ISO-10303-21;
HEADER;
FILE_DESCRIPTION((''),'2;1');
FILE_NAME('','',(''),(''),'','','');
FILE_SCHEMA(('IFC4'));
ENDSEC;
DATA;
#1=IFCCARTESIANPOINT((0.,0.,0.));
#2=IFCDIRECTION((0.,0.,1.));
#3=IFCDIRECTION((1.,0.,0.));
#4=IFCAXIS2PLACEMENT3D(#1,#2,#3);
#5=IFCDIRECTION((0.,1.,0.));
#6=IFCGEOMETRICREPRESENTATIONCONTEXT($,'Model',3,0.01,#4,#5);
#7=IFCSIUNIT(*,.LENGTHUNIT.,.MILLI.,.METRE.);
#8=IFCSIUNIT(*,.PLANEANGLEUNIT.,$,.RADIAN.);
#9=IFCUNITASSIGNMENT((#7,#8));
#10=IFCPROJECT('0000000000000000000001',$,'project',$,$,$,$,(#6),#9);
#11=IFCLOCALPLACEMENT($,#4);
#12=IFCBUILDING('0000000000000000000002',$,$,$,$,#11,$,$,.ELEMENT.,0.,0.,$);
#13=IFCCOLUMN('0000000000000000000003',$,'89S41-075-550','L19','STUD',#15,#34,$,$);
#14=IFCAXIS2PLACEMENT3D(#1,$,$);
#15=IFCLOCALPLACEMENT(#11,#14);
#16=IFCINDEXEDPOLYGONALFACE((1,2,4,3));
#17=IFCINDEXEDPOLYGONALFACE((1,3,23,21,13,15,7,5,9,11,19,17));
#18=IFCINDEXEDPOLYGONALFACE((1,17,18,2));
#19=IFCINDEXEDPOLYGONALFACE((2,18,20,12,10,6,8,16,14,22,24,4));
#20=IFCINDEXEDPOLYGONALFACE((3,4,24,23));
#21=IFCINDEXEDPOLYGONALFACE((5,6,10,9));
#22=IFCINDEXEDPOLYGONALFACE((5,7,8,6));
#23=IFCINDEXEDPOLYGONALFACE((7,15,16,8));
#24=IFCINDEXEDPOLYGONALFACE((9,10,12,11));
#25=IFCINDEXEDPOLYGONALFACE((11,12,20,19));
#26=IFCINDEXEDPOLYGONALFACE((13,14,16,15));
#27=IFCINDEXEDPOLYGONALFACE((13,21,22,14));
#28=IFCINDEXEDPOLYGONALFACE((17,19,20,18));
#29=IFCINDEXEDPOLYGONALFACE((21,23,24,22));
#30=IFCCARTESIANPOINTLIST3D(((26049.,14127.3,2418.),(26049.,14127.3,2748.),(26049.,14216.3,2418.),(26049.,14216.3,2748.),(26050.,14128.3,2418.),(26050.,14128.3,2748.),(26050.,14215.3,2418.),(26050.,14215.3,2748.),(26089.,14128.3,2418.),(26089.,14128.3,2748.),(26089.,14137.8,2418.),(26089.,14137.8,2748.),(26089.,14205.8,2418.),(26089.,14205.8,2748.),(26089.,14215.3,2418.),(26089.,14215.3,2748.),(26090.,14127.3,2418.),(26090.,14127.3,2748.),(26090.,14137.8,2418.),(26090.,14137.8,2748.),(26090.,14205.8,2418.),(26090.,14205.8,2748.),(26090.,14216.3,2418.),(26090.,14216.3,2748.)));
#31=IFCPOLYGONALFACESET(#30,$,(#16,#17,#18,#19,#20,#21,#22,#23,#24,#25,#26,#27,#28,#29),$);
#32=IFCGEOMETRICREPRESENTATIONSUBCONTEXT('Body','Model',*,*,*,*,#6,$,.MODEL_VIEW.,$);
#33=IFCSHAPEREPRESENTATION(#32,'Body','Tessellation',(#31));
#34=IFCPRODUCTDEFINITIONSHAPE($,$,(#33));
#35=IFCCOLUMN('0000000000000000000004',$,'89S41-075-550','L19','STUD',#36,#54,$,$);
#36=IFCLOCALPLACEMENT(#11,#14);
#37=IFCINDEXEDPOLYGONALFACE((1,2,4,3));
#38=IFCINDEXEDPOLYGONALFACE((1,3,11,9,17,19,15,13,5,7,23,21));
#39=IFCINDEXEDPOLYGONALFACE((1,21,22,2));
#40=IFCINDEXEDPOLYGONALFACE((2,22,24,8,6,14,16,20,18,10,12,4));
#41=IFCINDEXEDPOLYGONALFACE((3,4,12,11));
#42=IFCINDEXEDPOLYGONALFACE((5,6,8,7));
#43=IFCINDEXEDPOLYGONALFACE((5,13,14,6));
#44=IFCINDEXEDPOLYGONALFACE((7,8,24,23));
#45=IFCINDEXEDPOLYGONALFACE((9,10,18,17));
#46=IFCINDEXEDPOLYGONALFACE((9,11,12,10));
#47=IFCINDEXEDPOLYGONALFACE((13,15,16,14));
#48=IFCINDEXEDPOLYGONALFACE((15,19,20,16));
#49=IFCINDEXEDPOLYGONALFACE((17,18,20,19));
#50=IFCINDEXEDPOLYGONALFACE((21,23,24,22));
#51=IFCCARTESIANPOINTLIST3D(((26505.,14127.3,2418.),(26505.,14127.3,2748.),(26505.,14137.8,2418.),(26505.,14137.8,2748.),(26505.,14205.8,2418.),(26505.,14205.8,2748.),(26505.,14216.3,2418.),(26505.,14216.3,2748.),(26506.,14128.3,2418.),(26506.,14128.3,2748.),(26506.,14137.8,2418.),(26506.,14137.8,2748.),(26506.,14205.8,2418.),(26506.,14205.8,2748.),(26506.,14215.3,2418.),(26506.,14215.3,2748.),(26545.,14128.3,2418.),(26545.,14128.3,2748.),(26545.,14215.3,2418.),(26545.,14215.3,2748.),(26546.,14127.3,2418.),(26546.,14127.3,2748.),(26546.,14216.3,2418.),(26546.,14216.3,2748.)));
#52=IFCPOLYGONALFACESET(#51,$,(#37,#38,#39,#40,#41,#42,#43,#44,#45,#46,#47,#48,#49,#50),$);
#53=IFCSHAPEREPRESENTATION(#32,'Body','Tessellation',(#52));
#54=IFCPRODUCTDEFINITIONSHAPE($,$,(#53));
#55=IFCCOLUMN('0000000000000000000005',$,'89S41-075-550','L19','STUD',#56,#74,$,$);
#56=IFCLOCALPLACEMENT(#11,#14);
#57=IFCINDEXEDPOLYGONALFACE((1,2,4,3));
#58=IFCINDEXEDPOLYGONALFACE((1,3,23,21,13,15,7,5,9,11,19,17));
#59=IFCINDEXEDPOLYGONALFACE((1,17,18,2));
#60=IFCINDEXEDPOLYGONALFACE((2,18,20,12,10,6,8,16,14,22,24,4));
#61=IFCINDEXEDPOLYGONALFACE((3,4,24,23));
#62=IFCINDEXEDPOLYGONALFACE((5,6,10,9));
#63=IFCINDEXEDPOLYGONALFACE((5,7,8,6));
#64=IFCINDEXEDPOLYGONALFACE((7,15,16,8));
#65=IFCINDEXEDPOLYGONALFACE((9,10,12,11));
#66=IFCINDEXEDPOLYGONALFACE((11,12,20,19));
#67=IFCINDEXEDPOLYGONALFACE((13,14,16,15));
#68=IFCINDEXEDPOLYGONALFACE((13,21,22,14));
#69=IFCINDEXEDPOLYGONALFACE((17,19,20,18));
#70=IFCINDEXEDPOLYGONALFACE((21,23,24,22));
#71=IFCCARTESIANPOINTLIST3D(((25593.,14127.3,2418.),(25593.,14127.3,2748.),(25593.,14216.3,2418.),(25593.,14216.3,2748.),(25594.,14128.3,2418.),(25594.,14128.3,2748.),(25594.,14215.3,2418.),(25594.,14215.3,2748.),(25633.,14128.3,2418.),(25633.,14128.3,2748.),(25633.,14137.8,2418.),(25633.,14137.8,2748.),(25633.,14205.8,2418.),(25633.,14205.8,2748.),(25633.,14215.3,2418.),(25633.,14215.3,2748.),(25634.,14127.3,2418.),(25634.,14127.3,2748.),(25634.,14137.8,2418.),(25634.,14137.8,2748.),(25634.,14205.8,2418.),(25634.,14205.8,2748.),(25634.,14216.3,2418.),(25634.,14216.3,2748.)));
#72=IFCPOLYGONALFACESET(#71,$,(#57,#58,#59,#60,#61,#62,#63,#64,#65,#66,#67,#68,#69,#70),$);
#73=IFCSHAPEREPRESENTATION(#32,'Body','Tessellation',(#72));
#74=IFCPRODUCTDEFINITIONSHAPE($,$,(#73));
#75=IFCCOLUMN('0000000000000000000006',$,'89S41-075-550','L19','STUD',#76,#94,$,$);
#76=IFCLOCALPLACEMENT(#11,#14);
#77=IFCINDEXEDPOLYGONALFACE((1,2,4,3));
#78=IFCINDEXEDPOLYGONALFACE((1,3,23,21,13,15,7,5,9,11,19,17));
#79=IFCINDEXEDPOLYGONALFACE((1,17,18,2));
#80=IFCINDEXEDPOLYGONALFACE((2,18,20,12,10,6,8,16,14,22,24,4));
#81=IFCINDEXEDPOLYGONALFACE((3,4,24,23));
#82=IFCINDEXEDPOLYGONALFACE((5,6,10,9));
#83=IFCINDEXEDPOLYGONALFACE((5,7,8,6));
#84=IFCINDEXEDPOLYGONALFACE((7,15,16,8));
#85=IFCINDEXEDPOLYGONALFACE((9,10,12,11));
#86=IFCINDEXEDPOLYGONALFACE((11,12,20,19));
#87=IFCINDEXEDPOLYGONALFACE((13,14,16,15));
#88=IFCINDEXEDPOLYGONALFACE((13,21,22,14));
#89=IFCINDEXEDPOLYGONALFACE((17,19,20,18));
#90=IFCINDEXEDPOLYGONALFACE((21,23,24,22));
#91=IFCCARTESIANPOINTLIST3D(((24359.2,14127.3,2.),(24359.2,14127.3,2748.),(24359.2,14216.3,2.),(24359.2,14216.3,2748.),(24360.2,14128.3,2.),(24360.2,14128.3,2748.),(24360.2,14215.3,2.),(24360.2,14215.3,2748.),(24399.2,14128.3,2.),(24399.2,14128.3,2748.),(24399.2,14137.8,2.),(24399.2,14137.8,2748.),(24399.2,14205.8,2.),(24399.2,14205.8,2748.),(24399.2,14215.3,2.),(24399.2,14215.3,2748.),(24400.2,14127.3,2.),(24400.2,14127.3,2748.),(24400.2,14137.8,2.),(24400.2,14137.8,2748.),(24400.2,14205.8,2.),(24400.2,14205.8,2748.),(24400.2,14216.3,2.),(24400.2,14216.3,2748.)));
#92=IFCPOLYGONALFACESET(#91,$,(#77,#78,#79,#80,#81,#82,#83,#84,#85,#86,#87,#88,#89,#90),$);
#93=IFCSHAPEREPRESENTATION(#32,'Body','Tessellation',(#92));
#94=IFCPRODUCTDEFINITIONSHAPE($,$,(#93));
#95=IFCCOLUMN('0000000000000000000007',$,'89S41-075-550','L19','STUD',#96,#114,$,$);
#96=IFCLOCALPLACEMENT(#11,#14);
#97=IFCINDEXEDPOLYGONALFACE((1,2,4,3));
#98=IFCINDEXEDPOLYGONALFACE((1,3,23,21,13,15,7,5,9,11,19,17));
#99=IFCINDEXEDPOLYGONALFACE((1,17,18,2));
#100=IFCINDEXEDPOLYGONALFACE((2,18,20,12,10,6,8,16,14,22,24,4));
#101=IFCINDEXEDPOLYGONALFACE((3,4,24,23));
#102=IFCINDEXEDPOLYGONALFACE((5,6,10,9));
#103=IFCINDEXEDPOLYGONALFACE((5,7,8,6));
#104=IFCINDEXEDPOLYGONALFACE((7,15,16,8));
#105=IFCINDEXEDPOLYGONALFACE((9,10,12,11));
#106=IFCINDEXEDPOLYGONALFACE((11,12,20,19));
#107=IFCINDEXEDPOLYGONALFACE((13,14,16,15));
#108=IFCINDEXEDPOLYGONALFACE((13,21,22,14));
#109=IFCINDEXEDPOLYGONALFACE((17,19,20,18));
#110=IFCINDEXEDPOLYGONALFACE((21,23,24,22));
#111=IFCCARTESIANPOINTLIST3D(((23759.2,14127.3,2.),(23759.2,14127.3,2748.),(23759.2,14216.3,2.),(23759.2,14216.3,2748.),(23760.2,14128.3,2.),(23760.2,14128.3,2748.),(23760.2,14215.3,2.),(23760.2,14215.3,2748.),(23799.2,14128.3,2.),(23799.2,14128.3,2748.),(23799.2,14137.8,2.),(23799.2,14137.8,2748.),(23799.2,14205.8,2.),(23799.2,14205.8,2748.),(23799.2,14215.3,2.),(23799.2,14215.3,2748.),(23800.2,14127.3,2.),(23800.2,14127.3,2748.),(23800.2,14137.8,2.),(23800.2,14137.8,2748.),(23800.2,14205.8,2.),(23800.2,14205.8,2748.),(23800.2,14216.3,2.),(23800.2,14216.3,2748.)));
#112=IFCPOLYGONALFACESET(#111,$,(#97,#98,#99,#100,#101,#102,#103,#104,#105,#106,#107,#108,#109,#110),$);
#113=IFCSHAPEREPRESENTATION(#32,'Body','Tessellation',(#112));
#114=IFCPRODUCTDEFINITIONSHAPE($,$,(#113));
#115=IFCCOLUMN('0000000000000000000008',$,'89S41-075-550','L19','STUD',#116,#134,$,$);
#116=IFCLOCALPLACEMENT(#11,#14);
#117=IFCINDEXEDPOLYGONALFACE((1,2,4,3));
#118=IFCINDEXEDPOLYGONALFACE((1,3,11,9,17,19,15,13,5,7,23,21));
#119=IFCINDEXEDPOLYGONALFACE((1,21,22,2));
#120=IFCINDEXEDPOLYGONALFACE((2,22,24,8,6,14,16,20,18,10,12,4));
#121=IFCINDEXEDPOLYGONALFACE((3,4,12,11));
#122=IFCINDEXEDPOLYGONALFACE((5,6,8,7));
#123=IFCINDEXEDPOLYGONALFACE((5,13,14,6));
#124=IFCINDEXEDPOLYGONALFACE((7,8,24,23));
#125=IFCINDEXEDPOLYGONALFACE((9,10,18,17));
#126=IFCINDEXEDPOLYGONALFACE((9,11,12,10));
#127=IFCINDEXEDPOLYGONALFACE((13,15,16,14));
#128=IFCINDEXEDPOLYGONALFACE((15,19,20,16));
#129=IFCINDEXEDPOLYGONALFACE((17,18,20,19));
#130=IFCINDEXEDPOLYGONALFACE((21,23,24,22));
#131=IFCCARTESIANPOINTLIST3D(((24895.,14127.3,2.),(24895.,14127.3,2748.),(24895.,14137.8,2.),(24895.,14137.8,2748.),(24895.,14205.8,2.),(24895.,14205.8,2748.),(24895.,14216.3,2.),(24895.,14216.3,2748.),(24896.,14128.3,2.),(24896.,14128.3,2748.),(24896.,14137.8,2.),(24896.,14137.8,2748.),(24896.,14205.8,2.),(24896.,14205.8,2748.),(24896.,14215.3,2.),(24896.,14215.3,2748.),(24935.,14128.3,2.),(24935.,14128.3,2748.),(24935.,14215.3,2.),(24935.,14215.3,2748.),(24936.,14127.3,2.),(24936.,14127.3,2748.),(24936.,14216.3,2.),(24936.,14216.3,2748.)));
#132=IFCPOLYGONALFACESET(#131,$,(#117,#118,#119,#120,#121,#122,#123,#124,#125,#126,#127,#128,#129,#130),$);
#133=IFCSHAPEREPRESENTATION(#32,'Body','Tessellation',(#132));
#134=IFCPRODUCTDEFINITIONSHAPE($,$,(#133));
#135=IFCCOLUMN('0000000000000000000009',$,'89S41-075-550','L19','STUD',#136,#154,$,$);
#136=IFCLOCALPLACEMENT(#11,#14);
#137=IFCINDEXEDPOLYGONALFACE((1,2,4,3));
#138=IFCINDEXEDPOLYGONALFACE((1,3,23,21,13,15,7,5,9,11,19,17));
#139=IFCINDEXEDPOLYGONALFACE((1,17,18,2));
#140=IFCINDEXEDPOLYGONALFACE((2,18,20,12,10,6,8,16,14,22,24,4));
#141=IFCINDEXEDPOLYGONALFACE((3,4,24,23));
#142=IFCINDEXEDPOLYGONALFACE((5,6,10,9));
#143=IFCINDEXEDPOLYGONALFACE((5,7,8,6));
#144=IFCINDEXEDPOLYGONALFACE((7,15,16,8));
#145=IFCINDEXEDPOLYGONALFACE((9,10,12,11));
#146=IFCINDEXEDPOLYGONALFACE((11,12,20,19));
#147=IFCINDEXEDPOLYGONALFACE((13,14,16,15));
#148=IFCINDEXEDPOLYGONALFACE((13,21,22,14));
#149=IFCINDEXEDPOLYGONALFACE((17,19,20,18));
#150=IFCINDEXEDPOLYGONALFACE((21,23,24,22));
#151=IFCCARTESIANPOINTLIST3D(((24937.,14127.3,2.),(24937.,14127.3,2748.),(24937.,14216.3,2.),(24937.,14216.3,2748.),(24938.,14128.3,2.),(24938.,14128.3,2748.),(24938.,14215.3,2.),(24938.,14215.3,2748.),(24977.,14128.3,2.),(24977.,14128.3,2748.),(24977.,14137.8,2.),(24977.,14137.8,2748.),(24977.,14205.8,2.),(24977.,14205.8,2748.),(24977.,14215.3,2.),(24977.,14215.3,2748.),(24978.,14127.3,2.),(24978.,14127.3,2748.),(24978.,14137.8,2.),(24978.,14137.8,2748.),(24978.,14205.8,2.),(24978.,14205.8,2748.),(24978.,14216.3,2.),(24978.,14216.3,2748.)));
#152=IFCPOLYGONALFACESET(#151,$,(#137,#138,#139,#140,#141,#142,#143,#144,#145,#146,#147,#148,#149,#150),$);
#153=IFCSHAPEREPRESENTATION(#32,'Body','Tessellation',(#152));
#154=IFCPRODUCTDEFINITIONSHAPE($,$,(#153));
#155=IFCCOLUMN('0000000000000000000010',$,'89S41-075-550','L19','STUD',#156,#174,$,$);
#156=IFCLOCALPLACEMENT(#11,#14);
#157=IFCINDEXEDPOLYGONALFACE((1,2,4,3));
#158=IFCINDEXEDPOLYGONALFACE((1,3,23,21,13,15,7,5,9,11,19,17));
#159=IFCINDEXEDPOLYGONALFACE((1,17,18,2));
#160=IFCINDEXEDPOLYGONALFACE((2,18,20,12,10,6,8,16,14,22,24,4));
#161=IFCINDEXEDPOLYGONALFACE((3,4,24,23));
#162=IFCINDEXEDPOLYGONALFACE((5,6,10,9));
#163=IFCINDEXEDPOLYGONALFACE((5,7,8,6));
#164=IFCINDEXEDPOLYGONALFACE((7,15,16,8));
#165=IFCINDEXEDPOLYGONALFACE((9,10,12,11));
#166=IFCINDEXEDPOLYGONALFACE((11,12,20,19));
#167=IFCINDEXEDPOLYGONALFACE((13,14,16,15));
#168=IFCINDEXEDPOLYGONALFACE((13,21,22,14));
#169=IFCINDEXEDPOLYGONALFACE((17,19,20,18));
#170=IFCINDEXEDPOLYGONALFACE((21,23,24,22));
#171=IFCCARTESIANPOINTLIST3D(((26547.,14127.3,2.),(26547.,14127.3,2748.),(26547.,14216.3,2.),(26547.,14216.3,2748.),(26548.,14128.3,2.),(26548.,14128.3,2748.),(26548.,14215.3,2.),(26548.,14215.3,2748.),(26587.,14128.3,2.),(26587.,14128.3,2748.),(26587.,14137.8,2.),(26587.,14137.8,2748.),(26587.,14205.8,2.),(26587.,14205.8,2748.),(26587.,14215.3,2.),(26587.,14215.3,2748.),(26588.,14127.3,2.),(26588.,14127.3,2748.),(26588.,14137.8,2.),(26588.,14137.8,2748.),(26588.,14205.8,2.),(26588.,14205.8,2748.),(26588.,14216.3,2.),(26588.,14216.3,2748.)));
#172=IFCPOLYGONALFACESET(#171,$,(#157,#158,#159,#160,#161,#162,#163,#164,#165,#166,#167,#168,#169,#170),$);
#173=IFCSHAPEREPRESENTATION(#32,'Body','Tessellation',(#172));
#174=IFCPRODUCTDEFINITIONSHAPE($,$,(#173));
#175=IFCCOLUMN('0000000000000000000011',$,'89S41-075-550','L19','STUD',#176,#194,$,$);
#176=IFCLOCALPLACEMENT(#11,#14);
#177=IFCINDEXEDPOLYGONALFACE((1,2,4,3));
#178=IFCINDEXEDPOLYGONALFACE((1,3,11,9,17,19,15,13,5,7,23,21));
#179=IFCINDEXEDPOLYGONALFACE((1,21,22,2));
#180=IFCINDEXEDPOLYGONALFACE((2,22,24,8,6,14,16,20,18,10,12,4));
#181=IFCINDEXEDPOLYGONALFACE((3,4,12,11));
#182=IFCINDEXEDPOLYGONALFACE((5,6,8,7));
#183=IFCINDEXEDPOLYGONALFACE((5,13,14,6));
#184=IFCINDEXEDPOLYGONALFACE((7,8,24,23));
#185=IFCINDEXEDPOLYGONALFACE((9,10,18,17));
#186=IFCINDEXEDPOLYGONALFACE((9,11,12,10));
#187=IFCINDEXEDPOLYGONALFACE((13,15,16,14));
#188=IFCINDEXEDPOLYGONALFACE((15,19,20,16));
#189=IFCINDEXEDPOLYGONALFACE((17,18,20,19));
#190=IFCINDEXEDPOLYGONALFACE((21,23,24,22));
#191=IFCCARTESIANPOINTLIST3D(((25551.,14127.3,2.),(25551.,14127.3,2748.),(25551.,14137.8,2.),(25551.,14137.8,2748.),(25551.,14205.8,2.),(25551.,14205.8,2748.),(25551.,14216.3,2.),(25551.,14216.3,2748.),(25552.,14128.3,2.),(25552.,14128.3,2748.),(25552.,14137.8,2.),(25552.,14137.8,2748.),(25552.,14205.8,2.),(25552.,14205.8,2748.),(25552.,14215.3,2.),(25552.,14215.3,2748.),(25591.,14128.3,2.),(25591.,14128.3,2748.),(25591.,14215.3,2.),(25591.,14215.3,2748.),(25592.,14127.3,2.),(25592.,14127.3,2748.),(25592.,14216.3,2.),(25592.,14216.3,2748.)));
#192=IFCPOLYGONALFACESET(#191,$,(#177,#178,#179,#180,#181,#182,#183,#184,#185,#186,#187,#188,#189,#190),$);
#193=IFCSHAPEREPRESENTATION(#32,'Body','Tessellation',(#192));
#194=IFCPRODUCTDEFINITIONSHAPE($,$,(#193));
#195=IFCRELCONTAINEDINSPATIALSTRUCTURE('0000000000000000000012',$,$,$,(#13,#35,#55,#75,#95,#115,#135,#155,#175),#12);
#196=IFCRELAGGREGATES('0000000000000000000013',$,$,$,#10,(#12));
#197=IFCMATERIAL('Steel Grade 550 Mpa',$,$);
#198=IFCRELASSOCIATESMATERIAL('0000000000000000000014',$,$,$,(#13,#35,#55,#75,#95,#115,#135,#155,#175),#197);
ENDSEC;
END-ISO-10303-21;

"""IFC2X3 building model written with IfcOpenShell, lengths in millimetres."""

from ifc_helpers import new_model, si_unit, direction, frame, origin, origin_with_axes, origin_2d_with_axis, place, context, subcontext, project, spatial, c_section, extrude, source, transform, mapped, material, element, save


model = new_model("IFC2X3")

# Units and contexts
model_context = context("Model", 3, precision=0.01, world=origin_with_axes(), true_north=direction((0.0, 1.0, 0.0)))
body_context = subcontext(model_context, "Body", "Model", "MODEL_VIEW")
ifc_project = project(units=[si_unit("LENGTHUNIT", "METRE", prefix="MILLI"), si_unit("PLANEANGLEUNIT", "RADIAN")], contexts=[model_context])

# Building
building_placement = place(None, origin_with_axes())
building = spatial("IfcBuilding", under=ifc_project, at=building_placement, CompositionType="ELEMENT", ElevationOfRefHeight=0.0, ElevationOfTerrain=0.0)

# Columns
ifc_material = material(Name="Steel Grade 550 Mpa")
shared_shape_1 = source(origin(), body_context, "Body", "SweptSolid", [
    extrude(c_section(Depth=89.0, Width=41.0, WallThickness=1.0, Girth=10.5, at=origin_2d_with_axis()), origin_with_axes(), (0.0, 0.0, 1.0), 330.0),
])
column_1_placement = place(None, frame((26069.5, 14171.8, 2418.0), z_axis=(0.0, 0.0, 1.0), x_axis=(1.0, 0.0, 0.0)))
element("IfcColumn", 1, at=column_1_placement, inside=building, material=ifc_material, Name="89S41-075-550", Description="L19", ObjectType="STUD", context=body_context, shape_type="MappedRepresentation", body=[
    mapped(shared_shape_1, transform((0.0, 0.0, 0.0), scale=1.0)),
])
shared_shape_2 = source(origin(), body_context, "Body", "SweptSolid", [
    extrude(c_section(Depth=89.0, Width=41.0, WallThickness=1.0, Girth=10.5, at=origin_2d_with_axis()), origin_with_axes(), (0.0, 0.0, 1.0), 330.0),
])
column_2_placement = place(None, frame((26525.5, 14171.8, 2418.0), z_axis=(0.0, 0.0, 1.0), x_axis=(-1.0, 0.0, 0.0)))
element("IfcColumn", 2, at=column_2_placement, inside=building, material=ifc_material, Name="89S41-075-550", Description="L19", ObjectType="STUD", context=body_context, shape_type="MappedRepresentation", body=[
    mapped(shared_shape_2, transform((0.0, 0.0, 0.0), scale=1.0)),
])
shared_shape_3 = source(origin(), body_context, "Body", "SweptSolid", [
    extrude(c_section(Depth=89.0, Width=41.0, WallThickness=1.0, Girth=10.5, at=origin_2d_with_axis()), origin_with_axes(), (0.0, 0.0, 1.0), 330.0),
])
column_3_placement = place(None, frame((25613.5, 14171.8, 2418.0), z_axis=(0.0, 0.0, 1.0), x_axis=(1.0, 0.0, 0.0)))
element("IfcColumn", 3, at=column_3_placement, inside=building, material=ifc_material, Name="89S41-075-550", Description="L19", ObjectType="STUD", context=body_context, shape_type="MappedRepresentation", body=[
    mapped(shared_shape_3, transform((0.0, 0.0, 0.0), scale=1.0)),
])
shared_shape_4 = source(origin(), body_context, "Body", "SweptSolid", [
    extrude(c_section(Depth=89.0, Width=41.0, WallThickness=1.0, Girth=10.5, at=origin_2d_with_axis()), origin_with_axes(), (0.0, 0.0, 1.0), 2746.0),
])
column_4_placement = place(None, frame((24379.7, 14171.8, 2.0), z_axis=(0.0, 0.0, 1.0), x_axis=(1.0, 0.0, 0.0)))
element("IfcColumn", 4, at=column_4_placement, inside=building, material=ifc_material, Name="89S41-075-550", Description="L19", ObjectType="STUD", context=body_context, shape_type="MappedRepresentation", body=[
    mapped(shared_shape_4, transform((0.0, 0.0, 0.0), scale=1.0)),
])
shared_shape_5 = source(origin(), body_context, "Body", "SweptSolid", [
    extrude(c_section(Depth=89.0, Width=41.0, WallThickness=1.0, Girth=10.5, at=origin_2d_with_axis()), origin_with_axes(), (0.0, 0.0, 1.0), 2746.0),
])
column_5_placement = place(None, frame((23779.7, 14171.8, 2.0), z_axis=(0.0, 0.0, 1.0), x_axis=(1.0, 0.0, 0.0)))
element("IfcColumn", 5, at=column_5_placement, inside=building, material=ifc_material, Name="89S41-075-550", Description="L19", ObjectType="STUD", context=body_context, shape_type="MappedRepresentation", body=[
    mapped(shared_shape_5, transform((0.0, 0.0, 0.0), scale=1.0)),
])
shared_shape_6 = source(origin(), body_context, "Body", "SweptSolid", [
    extrude(c_section(Depth=89.0, Width=41.0, WallThickness=1.0, Girth=10.5, at=origin_2d_with_axis()), origin_with_axes(), (0.0, 0.0, 1.0), 2746.0),
])
column_6_placement = place(None, frame((24915.5, 14171.8, 2.0), z_axis=(0.0, 0.0, 1.0), x_axis=(-1.0, 0.0, 0.0)))
element("IfcColumn", 6, at=column_6_placement, inside=building, material=ifc_material, Name="89S41-075-550", Description="L19", ObjectType="STUD", context=body_context, shape_type="MappedRepresentation", body=[
    mapped(shared_shape_6, transform((0.0, 0.0, 0.0), scale=1.0)),
])
shared_shape_7 = source(origin(), body_context, "Body", "SweptSolid", [
    extrude(c_section(Depth=89.0, Width=41.0, WallThickness=1.0, Girth=10.5, at=origin_2d_with_axis()), origin_with_axes(), (0.0, 0.0, 1.0), 2746.0),
])
column_7_placement = place(None, frame((24957.5, 14171.8, 2.0), z_axis=(0.0, 0.0, 1.0), x_axis=(1.0, 0.0, 0.0)))
element("IfcColumn", 7, at=column_7_placement, inside=building, material=ifc_material, Name="89S41-075-550", Description="L19", ObjectType="STUD", context=body_context, shape_type="MappedRepresentation", body=[
    mapped(shared_shape_7, transform((0.0, 0.0, 0.0), scale=1.0)),
])
shared_shape_8 = source(origin(), body_context, "Body", "SweptSolid", [
    extrude(c_section(Depth=89.0, Width=41.0, WallThickness=1.0, Girth=10.5, at=origin_2d_with_axis()), origin_with_axes(), (0.0, 0.0, 1.0), 2746.0),
])
column_8_placement = place(None, frame((26567.5, 14171.8, 2.0), z_axis=(0.0, 0.0, 1.0), x_axis=(1.0, 0.0, 0.0)))
element("IfcColumn", 8, at=column_8_placement, inside=building, material=ifc_material, Name="89S41-075-550", Description="L19", ObjectType="STUD", context=body_context, shape_type="MappedRepresentation", body=[
    mapped(shared_shape_8, transform((0.0, 0.0, 0.0), scale=1.0)),
])
shared_shape_9 = source(origin(), body_context, "Body", "SweptSolid", [
    extrude(c_section(Depth=89.0, Width=41.0, WallThickness=1.0, Girth=10.5, at=origin_2d_with_axis()), origin_with_axes(), (0.0, 0.0, 1.0), 2746.0),
])
column_9_placement = place(None, frame((25571.5, 14171.8, 2.0), z_axis=(0.0, 0.0, 1.0), x_axis=(-1.0, 0.0, 0.0)))
element("IfcColumn", 9, at=column_9_placement, inside=building, material=ifc_material, Name="89S41-075-550", Description="L19", ObjectType="STUD", context=body_context, shape_type="MappedRepresentation", body=[
    mapped(shared_shape_9, transform((0.0, 0.0, 0.0), scale=1.0)),
])

save(model, "model.ifc")
